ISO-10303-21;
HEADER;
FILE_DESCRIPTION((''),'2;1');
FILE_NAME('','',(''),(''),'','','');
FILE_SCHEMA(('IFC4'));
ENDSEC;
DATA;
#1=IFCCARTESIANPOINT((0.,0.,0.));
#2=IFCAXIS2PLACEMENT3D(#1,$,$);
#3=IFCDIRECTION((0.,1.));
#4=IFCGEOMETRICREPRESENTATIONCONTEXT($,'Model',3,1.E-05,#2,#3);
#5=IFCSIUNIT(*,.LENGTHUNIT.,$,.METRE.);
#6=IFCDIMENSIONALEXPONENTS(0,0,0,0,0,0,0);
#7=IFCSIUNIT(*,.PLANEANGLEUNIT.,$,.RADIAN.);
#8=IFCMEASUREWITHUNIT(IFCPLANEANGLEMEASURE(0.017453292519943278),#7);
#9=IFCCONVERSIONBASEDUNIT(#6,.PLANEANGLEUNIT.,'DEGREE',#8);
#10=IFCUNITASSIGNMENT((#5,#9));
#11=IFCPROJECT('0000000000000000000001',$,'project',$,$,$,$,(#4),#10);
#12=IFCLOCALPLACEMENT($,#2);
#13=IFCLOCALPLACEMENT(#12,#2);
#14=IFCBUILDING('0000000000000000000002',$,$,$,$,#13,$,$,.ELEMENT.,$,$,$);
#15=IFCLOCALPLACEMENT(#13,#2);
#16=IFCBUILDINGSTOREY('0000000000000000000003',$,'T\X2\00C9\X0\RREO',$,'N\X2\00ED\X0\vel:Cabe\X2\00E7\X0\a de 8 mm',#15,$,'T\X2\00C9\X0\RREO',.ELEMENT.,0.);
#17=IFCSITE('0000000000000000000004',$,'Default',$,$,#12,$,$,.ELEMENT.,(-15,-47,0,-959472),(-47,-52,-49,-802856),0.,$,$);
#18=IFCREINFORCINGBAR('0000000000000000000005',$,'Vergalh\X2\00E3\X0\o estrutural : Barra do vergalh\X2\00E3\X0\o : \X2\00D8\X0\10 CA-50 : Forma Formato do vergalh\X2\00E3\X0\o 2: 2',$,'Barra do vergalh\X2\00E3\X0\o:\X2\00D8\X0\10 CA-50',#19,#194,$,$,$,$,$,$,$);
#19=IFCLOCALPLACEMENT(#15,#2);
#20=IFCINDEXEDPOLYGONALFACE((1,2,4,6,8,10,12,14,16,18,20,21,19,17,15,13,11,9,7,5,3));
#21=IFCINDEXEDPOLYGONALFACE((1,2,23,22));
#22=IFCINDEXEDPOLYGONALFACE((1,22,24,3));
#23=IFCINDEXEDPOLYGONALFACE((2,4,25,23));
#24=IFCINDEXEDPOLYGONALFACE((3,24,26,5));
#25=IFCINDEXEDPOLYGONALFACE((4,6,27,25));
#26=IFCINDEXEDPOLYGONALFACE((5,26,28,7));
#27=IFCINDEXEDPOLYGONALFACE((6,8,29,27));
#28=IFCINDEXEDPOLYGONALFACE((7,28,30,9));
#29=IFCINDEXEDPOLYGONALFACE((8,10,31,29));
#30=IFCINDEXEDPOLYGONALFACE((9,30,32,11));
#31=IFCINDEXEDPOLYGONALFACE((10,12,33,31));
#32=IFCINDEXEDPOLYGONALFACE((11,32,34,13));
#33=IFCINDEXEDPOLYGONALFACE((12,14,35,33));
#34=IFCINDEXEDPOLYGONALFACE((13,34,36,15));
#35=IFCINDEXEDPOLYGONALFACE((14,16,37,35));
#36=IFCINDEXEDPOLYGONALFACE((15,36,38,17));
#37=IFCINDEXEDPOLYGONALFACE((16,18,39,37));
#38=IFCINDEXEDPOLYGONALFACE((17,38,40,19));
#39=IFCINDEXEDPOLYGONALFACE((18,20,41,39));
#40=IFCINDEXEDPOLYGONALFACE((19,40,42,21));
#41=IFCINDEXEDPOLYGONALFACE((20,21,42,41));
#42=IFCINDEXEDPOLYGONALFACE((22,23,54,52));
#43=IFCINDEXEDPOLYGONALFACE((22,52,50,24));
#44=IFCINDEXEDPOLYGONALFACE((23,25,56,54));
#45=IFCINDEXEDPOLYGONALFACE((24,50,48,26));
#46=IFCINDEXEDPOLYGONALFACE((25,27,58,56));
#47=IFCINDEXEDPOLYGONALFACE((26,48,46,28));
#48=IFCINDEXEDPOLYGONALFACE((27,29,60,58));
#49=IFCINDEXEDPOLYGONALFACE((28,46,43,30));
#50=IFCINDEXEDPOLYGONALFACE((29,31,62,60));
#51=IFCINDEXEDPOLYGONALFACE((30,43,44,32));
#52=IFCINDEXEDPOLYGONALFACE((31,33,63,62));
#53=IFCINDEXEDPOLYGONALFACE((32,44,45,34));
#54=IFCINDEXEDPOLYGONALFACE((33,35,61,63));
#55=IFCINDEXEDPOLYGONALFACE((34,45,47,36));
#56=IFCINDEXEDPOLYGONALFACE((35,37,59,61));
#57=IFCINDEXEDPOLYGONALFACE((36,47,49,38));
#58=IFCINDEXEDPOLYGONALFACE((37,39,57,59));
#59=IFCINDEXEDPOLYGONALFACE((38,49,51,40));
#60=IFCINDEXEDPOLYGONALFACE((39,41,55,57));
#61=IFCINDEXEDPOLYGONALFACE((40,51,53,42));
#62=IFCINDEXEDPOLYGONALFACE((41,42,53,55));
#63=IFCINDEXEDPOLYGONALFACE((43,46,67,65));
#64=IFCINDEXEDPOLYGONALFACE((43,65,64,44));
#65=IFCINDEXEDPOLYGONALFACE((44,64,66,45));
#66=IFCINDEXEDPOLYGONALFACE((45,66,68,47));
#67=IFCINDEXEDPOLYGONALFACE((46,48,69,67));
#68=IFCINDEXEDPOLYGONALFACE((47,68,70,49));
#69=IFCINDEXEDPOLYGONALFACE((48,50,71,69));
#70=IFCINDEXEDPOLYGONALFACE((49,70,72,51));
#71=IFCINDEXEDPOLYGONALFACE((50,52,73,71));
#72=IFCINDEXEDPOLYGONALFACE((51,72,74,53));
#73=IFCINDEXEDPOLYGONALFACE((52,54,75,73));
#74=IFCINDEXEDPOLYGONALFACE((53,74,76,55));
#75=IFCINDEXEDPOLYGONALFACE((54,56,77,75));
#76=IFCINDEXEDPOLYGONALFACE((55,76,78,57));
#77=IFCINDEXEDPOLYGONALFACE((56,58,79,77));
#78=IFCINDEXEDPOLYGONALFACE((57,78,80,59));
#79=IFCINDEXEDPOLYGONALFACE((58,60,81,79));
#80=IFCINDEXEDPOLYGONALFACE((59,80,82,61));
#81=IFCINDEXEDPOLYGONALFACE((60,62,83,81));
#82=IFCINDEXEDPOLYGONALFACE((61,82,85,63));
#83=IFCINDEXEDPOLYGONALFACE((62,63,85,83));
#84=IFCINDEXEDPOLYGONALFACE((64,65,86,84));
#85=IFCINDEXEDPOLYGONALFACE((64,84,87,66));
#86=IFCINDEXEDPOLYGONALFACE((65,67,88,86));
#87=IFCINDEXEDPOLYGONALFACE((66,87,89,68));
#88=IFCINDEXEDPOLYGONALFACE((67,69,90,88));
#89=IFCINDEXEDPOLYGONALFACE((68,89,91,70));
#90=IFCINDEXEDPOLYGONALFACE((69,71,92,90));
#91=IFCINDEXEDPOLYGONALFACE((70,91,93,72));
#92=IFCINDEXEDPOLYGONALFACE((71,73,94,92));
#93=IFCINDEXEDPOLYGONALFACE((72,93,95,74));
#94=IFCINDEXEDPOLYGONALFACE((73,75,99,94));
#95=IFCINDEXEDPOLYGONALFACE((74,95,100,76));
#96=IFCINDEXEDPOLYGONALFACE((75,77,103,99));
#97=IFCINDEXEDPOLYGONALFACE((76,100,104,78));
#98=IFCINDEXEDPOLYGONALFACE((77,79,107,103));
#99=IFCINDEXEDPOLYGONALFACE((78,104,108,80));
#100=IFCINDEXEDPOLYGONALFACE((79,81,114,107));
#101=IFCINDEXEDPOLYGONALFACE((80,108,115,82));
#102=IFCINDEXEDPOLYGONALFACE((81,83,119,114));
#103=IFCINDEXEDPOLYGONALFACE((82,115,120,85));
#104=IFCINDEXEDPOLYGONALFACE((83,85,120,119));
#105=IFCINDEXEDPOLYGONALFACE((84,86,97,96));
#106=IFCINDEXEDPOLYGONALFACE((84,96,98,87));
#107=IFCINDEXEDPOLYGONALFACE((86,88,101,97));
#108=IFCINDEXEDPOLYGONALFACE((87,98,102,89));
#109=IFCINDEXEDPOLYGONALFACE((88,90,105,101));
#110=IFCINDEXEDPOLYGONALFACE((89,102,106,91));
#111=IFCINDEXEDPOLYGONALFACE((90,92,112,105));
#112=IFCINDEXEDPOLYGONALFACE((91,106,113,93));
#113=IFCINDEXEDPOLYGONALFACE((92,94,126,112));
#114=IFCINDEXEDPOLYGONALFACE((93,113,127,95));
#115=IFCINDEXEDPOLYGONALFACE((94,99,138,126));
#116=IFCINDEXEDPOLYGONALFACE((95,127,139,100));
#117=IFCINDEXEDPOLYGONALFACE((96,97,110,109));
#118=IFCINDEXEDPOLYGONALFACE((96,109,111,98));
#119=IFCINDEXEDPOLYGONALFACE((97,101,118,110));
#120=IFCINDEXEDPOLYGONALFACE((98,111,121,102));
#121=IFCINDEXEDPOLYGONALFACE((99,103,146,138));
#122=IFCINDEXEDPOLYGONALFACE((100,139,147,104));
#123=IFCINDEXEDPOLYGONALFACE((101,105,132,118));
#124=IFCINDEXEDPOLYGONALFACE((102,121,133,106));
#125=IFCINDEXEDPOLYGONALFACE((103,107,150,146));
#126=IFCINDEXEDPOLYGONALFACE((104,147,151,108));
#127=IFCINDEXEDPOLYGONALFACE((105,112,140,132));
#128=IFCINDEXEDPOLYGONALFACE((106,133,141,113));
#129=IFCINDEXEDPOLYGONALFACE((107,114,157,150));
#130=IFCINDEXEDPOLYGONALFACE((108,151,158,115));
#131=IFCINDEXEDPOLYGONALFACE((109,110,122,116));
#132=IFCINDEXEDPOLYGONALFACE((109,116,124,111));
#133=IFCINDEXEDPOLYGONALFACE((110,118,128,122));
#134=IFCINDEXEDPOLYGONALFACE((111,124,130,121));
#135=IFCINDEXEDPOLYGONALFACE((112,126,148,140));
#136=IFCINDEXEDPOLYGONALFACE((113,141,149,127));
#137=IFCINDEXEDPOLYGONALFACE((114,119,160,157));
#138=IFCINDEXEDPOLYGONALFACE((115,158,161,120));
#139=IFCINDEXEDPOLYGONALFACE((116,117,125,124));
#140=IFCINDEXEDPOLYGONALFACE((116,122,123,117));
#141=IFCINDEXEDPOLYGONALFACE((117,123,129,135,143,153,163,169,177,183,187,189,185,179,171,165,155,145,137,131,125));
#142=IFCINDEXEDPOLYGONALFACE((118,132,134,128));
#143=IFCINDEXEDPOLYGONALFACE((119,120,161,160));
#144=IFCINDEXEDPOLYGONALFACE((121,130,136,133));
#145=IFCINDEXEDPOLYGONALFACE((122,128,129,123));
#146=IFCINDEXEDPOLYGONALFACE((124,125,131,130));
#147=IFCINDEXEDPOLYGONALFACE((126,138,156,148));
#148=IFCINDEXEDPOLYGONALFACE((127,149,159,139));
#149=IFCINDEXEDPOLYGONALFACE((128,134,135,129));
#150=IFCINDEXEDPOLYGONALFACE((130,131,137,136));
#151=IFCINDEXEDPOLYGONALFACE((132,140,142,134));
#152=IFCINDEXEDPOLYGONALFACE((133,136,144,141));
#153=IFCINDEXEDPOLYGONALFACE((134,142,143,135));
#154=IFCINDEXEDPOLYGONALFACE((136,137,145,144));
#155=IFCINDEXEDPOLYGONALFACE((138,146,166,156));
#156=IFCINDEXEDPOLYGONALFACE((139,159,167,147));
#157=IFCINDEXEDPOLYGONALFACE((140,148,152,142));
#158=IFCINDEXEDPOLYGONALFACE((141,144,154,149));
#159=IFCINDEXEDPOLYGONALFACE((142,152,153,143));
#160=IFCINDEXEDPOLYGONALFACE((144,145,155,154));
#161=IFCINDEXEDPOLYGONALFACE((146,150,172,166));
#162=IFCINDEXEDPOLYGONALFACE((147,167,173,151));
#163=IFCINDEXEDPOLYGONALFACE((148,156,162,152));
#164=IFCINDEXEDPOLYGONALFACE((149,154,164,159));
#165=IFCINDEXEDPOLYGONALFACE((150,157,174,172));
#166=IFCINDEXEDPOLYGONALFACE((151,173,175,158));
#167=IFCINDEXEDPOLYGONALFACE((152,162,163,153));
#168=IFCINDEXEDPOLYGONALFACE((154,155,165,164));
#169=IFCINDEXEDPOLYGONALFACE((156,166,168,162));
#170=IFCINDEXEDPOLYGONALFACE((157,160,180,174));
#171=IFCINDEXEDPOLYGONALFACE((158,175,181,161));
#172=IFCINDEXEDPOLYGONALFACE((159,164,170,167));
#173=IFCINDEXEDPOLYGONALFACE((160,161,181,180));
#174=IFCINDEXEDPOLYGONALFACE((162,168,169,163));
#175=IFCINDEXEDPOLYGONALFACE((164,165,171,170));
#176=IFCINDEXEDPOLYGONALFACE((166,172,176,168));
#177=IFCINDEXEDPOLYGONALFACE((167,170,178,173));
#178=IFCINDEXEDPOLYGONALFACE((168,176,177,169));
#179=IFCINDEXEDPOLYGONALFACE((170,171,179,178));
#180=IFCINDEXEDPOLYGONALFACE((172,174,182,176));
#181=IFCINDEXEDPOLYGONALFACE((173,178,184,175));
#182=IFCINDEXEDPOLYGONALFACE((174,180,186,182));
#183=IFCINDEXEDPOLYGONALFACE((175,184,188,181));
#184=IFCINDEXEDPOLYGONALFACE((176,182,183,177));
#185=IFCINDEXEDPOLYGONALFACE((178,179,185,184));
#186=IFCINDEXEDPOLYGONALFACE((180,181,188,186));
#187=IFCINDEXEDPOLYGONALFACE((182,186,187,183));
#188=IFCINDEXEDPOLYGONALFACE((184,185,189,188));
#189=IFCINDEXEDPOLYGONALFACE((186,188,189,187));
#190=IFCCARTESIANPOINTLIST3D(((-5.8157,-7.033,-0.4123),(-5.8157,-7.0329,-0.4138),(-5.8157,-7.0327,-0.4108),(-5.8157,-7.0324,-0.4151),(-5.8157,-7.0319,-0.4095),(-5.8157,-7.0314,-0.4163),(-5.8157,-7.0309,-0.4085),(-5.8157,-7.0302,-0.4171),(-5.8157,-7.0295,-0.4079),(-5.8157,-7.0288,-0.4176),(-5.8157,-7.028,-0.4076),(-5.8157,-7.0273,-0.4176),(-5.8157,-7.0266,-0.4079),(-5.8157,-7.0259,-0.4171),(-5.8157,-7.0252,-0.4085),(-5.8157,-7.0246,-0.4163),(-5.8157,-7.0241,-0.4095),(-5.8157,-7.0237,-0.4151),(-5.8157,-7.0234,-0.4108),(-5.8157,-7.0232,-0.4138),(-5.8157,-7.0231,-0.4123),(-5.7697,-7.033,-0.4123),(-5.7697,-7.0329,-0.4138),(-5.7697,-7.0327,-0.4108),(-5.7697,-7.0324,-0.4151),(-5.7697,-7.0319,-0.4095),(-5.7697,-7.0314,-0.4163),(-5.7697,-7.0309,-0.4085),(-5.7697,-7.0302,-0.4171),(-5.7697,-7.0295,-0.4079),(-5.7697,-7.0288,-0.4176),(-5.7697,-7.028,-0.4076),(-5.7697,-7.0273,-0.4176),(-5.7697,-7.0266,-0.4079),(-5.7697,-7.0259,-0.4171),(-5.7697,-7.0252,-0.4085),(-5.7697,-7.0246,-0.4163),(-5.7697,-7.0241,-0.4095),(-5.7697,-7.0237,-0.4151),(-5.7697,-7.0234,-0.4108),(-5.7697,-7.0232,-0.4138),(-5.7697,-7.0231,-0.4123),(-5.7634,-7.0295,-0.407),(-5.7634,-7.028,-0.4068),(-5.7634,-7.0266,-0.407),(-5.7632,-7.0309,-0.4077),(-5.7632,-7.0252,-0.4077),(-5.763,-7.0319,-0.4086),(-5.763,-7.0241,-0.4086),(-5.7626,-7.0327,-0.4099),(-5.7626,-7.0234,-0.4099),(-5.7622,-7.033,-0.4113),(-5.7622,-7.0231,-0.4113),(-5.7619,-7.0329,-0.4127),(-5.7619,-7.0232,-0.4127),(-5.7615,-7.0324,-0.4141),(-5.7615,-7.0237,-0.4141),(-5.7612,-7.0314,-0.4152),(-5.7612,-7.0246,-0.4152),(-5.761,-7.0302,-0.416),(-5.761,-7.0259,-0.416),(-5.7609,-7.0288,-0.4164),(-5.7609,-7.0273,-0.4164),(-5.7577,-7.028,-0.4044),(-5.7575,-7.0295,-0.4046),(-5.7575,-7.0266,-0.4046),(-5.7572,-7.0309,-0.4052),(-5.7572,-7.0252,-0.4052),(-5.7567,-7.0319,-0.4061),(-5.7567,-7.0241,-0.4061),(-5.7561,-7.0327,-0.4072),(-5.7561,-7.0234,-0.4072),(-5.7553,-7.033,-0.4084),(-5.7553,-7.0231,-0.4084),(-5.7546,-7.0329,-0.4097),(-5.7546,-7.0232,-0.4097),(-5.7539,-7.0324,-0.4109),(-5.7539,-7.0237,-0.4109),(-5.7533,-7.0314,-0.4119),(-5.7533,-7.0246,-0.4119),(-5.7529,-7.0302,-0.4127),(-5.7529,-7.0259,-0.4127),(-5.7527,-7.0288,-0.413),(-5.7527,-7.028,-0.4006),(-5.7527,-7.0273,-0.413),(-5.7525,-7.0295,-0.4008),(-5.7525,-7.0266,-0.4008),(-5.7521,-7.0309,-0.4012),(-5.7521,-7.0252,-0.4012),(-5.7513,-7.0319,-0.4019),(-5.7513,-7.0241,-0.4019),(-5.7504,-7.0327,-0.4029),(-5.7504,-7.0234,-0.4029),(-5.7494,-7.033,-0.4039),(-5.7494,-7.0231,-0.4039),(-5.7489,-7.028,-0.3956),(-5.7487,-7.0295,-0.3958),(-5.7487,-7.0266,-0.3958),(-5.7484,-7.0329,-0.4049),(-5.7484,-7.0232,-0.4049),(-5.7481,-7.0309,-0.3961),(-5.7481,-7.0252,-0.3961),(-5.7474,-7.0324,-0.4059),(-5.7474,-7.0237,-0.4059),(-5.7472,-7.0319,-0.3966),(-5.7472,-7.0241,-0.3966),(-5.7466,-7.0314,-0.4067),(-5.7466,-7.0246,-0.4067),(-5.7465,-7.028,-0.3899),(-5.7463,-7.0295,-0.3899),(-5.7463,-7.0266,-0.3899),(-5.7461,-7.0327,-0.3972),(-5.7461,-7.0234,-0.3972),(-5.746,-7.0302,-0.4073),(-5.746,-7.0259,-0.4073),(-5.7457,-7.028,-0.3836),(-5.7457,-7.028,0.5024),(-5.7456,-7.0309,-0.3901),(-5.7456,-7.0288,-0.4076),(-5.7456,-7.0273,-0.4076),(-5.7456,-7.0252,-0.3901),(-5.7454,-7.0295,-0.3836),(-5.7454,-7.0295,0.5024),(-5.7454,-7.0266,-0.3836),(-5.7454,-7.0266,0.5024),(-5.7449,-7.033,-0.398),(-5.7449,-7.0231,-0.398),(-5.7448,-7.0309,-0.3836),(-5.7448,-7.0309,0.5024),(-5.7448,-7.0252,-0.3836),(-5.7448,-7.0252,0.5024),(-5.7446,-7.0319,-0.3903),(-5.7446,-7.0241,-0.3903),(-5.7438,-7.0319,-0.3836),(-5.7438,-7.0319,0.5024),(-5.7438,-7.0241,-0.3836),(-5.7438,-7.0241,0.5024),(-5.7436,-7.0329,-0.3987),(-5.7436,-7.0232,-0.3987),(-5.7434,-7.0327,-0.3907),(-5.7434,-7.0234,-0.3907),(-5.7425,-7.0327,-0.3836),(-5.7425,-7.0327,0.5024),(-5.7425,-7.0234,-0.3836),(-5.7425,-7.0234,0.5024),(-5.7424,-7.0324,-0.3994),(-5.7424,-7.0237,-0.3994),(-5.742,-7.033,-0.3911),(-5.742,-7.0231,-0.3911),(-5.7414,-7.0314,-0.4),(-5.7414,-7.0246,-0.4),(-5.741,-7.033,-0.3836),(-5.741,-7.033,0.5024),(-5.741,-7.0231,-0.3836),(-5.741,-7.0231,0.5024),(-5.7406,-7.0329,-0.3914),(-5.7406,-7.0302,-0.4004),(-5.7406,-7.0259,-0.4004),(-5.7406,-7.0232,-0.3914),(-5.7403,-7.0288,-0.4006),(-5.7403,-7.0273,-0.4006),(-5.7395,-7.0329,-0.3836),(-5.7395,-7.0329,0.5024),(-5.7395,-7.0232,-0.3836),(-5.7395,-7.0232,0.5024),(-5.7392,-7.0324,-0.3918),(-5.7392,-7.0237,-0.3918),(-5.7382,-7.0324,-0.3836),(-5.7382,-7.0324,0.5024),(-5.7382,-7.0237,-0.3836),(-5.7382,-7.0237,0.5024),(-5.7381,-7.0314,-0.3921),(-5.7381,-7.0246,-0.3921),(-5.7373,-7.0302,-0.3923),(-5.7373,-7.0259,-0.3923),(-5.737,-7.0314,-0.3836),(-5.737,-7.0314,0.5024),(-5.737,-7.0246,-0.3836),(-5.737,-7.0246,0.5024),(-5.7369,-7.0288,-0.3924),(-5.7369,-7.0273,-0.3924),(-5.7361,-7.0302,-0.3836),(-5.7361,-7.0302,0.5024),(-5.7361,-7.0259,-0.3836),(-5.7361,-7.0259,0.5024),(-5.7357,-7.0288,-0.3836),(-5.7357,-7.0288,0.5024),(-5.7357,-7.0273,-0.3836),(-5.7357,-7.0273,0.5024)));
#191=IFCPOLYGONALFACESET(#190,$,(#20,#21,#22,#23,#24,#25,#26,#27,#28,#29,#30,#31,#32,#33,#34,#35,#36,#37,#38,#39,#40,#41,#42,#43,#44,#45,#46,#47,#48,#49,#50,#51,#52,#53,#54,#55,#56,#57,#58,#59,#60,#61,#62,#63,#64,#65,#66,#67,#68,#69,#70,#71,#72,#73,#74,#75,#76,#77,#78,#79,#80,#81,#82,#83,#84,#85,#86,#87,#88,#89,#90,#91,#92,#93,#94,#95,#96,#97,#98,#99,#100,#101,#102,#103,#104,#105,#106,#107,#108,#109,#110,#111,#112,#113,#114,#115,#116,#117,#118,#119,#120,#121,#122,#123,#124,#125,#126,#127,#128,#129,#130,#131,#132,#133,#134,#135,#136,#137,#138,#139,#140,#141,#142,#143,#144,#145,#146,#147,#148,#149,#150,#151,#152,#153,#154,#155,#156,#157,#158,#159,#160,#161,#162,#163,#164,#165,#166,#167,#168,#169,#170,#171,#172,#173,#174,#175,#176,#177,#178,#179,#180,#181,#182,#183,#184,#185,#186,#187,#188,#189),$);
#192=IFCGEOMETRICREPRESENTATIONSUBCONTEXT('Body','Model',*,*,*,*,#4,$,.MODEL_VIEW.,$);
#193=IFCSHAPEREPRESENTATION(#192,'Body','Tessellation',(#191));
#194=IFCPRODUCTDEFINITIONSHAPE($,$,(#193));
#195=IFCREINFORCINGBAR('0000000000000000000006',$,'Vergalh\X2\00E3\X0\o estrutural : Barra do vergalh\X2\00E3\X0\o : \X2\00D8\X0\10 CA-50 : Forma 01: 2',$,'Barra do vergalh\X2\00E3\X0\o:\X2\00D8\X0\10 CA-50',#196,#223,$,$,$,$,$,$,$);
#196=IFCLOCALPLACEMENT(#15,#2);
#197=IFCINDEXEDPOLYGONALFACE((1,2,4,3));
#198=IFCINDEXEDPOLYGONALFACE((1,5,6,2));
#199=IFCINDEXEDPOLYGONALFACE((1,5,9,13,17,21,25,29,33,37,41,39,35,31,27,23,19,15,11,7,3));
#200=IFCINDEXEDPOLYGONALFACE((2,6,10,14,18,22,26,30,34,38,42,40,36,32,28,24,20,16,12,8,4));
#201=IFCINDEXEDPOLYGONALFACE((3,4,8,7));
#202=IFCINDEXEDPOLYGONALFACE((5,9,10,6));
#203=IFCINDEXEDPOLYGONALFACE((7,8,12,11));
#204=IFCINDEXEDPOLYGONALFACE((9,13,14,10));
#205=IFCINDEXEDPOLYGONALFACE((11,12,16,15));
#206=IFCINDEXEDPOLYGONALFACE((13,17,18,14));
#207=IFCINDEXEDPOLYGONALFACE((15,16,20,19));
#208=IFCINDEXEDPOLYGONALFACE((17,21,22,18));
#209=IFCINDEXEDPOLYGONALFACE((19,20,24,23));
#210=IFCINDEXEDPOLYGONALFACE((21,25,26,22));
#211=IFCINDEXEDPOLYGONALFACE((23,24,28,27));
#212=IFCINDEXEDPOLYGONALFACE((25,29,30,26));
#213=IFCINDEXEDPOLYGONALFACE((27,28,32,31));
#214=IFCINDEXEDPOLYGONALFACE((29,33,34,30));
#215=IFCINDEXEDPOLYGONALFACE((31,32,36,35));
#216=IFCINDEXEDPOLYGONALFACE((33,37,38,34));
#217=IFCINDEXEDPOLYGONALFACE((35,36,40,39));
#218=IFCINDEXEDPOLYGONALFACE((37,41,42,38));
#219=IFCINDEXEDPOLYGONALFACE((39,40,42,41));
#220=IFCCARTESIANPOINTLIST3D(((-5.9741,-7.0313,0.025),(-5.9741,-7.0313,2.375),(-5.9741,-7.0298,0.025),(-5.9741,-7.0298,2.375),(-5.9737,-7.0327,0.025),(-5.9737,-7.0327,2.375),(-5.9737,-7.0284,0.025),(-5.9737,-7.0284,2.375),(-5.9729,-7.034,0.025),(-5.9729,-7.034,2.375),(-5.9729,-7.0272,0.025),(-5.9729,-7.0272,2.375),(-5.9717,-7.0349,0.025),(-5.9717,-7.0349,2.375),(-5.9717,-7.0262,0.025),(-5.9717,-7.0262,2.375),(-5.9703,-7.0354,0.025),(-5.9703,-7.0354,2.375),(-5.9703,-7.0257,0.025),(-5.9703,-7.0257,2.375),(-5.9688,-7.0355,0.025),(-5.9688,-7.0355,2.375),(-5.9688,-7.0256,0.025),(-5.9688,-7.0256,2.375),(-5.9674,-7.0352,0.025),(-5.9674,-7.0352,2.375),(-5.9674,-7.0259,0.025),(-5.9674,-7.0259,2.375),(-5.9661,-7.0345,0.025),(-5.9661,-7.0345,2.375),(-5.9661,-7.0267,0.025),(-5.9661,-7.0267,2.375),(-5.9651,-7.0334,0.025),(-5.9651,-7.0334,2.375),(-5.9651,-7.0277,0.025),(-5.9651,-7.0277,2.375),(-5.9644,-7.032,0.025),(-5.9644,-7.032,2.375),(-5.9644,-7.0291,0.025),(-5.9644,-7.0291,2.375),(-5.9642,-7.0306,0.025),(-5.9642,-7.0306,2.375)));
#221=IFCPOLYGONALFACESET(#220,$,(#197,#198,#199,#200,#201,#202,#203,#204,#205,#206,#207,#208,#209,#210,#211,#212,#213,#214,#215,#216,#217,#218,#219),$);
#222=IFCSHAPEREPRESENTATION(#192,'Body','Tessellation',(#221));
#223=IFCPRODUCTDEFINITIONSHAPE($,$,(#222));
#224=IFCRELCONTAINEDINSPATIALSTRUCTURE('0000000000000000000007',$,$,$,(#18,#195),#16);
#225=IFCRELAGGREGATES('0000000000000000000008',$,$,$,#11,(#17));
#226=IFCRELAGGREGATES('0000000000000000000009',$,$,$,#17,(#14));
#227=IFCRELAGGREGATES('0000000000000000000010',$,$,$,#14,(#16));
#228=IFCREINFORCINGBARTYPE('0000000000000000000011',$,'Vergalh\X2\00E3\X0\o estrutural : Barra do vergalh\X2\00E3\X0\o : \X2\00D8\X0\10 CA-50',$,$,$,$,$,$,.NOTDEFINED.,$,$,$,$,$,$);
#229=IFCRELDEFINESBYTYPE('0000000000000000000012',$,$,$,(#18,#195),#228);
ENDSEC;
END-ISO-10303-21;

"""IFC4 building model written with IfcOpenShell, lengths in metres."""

from ifc_helpers import new_model, entity, si_unit, converted_unit, direction, origin, place, context, subcontext, project, spatial, type_object, element, save


model = new_model("IFC4")

# Units and contexts
model_context = context("Model", 3, precision=1e-05, world=origin(), true_north=direction((0.0, 1.0)))
body_context = subcontext(model_context, "Body", "Model", "MODEL_VIEW")
ifc_project = project(units=[si_unit("LENGTHUNIT", "METRE"), converted_unit("PLANEANGLEUNIT", "DEGREE", entity("IfcPlaneAngleMeasure", 0.017453292519943278), si_unit("PLANEANGLEUNIT", "RADIAN"), dimensions=[0, 0, 0, 0, 0, 0, 0])], contexts=[model_context])

# Site, building, storey
site_placement = place(None, origin())
site = spatial("IfcSite", under=ifc_project, at=site_placement, Name="Default", CompositionType="ELEMENT", RefLatitude=(-15, -47, 0, -959472), RefLongitude=(-47, -52, -49, -802856), RefElevation=0.0)
building_placement = place(site_placement, origin())
building = spatial("IfcBuilding", under=site, at=building_placement, CompositionType="ELEMENT")
storey_placement = place(building_placement, origin())
storey = spatial("IfcBuildingStorey", under=building, at=storey_placement, Name="TÉRREO", ObjectType="Nível:Cabeça de 8 mm", LongName="TÉRREO", CompositionType="ELEMENT", Elevation=0.0)

# Reinforcing bars
reinforcing_bar_type_1 = type_object("IfcReinforcingBarType", Name="Vergalhão estrutural : Barra do vergalhão : Ø10 CA-50", PredefinedType="NOTDEFINED")
reinforcing_bar_1_placement = place(storey_placement, origin())
element("IfcReinforcingBar", 1, at=reinforcing_bar_1_placement, inside=storey, type_object=reinforcing_bar_type_1, Name="Vergalhão estrutural : Barra do vergalhão : Ø10 CA-50 : Forma Formato do vergalhão 2: 2", ObjectType="Barra do vergalhão:Ø10 CA-50", context=body_context, shape_type="AdvancedSweptSolid", body=[
    entity("IfcSweptDiskSolid", entity("IfcIndexedPolyCurve", entity("IfcCartesianPointList3D", [[-5.8157, -7.028, -0.4126], [-5.7697, -7.028, -0.4126], [-5.7491, -7.028, -0.4042], [-5.7407, -7.028, -0.3836], [-5.7407, -7.028, 0.5024]]), [entity("IfcLineIndex", [1, 2]), entity("IfcArcIndex", [2, 3, 4]), entity("IfcLineIndex", [4, 5])], False), 0.005, None, 0.0, 92.0),
])
reinforcing_bar_2_placement = place(storey_placement, origin())
element("IfcReinforcingBar", 2, at=reinforcing_bar_2_placement, inside=storey, type_object=reinforcing_bar_type_1, Name="Vergalhão estrutural : Barra do vergalhão : Ø10 CA-50 : Forma 01: 2", ObjectType="Barra do vergalhão:Ø10 CA-50", context=body_context, shape_type="AdvancedSweptSolid", body=[
    entity("IfcSweptDiskSolid", entity("IfcIndexedPolyCurve", entity("IfcCartesianPointList3D", [[-5.9692, -7.0306, 0.025], [-5.9692, -7.0306, 2.375]]), None, False), 0.005, None, 0.0, 1.0),
])

save(model, "model.ifc")
